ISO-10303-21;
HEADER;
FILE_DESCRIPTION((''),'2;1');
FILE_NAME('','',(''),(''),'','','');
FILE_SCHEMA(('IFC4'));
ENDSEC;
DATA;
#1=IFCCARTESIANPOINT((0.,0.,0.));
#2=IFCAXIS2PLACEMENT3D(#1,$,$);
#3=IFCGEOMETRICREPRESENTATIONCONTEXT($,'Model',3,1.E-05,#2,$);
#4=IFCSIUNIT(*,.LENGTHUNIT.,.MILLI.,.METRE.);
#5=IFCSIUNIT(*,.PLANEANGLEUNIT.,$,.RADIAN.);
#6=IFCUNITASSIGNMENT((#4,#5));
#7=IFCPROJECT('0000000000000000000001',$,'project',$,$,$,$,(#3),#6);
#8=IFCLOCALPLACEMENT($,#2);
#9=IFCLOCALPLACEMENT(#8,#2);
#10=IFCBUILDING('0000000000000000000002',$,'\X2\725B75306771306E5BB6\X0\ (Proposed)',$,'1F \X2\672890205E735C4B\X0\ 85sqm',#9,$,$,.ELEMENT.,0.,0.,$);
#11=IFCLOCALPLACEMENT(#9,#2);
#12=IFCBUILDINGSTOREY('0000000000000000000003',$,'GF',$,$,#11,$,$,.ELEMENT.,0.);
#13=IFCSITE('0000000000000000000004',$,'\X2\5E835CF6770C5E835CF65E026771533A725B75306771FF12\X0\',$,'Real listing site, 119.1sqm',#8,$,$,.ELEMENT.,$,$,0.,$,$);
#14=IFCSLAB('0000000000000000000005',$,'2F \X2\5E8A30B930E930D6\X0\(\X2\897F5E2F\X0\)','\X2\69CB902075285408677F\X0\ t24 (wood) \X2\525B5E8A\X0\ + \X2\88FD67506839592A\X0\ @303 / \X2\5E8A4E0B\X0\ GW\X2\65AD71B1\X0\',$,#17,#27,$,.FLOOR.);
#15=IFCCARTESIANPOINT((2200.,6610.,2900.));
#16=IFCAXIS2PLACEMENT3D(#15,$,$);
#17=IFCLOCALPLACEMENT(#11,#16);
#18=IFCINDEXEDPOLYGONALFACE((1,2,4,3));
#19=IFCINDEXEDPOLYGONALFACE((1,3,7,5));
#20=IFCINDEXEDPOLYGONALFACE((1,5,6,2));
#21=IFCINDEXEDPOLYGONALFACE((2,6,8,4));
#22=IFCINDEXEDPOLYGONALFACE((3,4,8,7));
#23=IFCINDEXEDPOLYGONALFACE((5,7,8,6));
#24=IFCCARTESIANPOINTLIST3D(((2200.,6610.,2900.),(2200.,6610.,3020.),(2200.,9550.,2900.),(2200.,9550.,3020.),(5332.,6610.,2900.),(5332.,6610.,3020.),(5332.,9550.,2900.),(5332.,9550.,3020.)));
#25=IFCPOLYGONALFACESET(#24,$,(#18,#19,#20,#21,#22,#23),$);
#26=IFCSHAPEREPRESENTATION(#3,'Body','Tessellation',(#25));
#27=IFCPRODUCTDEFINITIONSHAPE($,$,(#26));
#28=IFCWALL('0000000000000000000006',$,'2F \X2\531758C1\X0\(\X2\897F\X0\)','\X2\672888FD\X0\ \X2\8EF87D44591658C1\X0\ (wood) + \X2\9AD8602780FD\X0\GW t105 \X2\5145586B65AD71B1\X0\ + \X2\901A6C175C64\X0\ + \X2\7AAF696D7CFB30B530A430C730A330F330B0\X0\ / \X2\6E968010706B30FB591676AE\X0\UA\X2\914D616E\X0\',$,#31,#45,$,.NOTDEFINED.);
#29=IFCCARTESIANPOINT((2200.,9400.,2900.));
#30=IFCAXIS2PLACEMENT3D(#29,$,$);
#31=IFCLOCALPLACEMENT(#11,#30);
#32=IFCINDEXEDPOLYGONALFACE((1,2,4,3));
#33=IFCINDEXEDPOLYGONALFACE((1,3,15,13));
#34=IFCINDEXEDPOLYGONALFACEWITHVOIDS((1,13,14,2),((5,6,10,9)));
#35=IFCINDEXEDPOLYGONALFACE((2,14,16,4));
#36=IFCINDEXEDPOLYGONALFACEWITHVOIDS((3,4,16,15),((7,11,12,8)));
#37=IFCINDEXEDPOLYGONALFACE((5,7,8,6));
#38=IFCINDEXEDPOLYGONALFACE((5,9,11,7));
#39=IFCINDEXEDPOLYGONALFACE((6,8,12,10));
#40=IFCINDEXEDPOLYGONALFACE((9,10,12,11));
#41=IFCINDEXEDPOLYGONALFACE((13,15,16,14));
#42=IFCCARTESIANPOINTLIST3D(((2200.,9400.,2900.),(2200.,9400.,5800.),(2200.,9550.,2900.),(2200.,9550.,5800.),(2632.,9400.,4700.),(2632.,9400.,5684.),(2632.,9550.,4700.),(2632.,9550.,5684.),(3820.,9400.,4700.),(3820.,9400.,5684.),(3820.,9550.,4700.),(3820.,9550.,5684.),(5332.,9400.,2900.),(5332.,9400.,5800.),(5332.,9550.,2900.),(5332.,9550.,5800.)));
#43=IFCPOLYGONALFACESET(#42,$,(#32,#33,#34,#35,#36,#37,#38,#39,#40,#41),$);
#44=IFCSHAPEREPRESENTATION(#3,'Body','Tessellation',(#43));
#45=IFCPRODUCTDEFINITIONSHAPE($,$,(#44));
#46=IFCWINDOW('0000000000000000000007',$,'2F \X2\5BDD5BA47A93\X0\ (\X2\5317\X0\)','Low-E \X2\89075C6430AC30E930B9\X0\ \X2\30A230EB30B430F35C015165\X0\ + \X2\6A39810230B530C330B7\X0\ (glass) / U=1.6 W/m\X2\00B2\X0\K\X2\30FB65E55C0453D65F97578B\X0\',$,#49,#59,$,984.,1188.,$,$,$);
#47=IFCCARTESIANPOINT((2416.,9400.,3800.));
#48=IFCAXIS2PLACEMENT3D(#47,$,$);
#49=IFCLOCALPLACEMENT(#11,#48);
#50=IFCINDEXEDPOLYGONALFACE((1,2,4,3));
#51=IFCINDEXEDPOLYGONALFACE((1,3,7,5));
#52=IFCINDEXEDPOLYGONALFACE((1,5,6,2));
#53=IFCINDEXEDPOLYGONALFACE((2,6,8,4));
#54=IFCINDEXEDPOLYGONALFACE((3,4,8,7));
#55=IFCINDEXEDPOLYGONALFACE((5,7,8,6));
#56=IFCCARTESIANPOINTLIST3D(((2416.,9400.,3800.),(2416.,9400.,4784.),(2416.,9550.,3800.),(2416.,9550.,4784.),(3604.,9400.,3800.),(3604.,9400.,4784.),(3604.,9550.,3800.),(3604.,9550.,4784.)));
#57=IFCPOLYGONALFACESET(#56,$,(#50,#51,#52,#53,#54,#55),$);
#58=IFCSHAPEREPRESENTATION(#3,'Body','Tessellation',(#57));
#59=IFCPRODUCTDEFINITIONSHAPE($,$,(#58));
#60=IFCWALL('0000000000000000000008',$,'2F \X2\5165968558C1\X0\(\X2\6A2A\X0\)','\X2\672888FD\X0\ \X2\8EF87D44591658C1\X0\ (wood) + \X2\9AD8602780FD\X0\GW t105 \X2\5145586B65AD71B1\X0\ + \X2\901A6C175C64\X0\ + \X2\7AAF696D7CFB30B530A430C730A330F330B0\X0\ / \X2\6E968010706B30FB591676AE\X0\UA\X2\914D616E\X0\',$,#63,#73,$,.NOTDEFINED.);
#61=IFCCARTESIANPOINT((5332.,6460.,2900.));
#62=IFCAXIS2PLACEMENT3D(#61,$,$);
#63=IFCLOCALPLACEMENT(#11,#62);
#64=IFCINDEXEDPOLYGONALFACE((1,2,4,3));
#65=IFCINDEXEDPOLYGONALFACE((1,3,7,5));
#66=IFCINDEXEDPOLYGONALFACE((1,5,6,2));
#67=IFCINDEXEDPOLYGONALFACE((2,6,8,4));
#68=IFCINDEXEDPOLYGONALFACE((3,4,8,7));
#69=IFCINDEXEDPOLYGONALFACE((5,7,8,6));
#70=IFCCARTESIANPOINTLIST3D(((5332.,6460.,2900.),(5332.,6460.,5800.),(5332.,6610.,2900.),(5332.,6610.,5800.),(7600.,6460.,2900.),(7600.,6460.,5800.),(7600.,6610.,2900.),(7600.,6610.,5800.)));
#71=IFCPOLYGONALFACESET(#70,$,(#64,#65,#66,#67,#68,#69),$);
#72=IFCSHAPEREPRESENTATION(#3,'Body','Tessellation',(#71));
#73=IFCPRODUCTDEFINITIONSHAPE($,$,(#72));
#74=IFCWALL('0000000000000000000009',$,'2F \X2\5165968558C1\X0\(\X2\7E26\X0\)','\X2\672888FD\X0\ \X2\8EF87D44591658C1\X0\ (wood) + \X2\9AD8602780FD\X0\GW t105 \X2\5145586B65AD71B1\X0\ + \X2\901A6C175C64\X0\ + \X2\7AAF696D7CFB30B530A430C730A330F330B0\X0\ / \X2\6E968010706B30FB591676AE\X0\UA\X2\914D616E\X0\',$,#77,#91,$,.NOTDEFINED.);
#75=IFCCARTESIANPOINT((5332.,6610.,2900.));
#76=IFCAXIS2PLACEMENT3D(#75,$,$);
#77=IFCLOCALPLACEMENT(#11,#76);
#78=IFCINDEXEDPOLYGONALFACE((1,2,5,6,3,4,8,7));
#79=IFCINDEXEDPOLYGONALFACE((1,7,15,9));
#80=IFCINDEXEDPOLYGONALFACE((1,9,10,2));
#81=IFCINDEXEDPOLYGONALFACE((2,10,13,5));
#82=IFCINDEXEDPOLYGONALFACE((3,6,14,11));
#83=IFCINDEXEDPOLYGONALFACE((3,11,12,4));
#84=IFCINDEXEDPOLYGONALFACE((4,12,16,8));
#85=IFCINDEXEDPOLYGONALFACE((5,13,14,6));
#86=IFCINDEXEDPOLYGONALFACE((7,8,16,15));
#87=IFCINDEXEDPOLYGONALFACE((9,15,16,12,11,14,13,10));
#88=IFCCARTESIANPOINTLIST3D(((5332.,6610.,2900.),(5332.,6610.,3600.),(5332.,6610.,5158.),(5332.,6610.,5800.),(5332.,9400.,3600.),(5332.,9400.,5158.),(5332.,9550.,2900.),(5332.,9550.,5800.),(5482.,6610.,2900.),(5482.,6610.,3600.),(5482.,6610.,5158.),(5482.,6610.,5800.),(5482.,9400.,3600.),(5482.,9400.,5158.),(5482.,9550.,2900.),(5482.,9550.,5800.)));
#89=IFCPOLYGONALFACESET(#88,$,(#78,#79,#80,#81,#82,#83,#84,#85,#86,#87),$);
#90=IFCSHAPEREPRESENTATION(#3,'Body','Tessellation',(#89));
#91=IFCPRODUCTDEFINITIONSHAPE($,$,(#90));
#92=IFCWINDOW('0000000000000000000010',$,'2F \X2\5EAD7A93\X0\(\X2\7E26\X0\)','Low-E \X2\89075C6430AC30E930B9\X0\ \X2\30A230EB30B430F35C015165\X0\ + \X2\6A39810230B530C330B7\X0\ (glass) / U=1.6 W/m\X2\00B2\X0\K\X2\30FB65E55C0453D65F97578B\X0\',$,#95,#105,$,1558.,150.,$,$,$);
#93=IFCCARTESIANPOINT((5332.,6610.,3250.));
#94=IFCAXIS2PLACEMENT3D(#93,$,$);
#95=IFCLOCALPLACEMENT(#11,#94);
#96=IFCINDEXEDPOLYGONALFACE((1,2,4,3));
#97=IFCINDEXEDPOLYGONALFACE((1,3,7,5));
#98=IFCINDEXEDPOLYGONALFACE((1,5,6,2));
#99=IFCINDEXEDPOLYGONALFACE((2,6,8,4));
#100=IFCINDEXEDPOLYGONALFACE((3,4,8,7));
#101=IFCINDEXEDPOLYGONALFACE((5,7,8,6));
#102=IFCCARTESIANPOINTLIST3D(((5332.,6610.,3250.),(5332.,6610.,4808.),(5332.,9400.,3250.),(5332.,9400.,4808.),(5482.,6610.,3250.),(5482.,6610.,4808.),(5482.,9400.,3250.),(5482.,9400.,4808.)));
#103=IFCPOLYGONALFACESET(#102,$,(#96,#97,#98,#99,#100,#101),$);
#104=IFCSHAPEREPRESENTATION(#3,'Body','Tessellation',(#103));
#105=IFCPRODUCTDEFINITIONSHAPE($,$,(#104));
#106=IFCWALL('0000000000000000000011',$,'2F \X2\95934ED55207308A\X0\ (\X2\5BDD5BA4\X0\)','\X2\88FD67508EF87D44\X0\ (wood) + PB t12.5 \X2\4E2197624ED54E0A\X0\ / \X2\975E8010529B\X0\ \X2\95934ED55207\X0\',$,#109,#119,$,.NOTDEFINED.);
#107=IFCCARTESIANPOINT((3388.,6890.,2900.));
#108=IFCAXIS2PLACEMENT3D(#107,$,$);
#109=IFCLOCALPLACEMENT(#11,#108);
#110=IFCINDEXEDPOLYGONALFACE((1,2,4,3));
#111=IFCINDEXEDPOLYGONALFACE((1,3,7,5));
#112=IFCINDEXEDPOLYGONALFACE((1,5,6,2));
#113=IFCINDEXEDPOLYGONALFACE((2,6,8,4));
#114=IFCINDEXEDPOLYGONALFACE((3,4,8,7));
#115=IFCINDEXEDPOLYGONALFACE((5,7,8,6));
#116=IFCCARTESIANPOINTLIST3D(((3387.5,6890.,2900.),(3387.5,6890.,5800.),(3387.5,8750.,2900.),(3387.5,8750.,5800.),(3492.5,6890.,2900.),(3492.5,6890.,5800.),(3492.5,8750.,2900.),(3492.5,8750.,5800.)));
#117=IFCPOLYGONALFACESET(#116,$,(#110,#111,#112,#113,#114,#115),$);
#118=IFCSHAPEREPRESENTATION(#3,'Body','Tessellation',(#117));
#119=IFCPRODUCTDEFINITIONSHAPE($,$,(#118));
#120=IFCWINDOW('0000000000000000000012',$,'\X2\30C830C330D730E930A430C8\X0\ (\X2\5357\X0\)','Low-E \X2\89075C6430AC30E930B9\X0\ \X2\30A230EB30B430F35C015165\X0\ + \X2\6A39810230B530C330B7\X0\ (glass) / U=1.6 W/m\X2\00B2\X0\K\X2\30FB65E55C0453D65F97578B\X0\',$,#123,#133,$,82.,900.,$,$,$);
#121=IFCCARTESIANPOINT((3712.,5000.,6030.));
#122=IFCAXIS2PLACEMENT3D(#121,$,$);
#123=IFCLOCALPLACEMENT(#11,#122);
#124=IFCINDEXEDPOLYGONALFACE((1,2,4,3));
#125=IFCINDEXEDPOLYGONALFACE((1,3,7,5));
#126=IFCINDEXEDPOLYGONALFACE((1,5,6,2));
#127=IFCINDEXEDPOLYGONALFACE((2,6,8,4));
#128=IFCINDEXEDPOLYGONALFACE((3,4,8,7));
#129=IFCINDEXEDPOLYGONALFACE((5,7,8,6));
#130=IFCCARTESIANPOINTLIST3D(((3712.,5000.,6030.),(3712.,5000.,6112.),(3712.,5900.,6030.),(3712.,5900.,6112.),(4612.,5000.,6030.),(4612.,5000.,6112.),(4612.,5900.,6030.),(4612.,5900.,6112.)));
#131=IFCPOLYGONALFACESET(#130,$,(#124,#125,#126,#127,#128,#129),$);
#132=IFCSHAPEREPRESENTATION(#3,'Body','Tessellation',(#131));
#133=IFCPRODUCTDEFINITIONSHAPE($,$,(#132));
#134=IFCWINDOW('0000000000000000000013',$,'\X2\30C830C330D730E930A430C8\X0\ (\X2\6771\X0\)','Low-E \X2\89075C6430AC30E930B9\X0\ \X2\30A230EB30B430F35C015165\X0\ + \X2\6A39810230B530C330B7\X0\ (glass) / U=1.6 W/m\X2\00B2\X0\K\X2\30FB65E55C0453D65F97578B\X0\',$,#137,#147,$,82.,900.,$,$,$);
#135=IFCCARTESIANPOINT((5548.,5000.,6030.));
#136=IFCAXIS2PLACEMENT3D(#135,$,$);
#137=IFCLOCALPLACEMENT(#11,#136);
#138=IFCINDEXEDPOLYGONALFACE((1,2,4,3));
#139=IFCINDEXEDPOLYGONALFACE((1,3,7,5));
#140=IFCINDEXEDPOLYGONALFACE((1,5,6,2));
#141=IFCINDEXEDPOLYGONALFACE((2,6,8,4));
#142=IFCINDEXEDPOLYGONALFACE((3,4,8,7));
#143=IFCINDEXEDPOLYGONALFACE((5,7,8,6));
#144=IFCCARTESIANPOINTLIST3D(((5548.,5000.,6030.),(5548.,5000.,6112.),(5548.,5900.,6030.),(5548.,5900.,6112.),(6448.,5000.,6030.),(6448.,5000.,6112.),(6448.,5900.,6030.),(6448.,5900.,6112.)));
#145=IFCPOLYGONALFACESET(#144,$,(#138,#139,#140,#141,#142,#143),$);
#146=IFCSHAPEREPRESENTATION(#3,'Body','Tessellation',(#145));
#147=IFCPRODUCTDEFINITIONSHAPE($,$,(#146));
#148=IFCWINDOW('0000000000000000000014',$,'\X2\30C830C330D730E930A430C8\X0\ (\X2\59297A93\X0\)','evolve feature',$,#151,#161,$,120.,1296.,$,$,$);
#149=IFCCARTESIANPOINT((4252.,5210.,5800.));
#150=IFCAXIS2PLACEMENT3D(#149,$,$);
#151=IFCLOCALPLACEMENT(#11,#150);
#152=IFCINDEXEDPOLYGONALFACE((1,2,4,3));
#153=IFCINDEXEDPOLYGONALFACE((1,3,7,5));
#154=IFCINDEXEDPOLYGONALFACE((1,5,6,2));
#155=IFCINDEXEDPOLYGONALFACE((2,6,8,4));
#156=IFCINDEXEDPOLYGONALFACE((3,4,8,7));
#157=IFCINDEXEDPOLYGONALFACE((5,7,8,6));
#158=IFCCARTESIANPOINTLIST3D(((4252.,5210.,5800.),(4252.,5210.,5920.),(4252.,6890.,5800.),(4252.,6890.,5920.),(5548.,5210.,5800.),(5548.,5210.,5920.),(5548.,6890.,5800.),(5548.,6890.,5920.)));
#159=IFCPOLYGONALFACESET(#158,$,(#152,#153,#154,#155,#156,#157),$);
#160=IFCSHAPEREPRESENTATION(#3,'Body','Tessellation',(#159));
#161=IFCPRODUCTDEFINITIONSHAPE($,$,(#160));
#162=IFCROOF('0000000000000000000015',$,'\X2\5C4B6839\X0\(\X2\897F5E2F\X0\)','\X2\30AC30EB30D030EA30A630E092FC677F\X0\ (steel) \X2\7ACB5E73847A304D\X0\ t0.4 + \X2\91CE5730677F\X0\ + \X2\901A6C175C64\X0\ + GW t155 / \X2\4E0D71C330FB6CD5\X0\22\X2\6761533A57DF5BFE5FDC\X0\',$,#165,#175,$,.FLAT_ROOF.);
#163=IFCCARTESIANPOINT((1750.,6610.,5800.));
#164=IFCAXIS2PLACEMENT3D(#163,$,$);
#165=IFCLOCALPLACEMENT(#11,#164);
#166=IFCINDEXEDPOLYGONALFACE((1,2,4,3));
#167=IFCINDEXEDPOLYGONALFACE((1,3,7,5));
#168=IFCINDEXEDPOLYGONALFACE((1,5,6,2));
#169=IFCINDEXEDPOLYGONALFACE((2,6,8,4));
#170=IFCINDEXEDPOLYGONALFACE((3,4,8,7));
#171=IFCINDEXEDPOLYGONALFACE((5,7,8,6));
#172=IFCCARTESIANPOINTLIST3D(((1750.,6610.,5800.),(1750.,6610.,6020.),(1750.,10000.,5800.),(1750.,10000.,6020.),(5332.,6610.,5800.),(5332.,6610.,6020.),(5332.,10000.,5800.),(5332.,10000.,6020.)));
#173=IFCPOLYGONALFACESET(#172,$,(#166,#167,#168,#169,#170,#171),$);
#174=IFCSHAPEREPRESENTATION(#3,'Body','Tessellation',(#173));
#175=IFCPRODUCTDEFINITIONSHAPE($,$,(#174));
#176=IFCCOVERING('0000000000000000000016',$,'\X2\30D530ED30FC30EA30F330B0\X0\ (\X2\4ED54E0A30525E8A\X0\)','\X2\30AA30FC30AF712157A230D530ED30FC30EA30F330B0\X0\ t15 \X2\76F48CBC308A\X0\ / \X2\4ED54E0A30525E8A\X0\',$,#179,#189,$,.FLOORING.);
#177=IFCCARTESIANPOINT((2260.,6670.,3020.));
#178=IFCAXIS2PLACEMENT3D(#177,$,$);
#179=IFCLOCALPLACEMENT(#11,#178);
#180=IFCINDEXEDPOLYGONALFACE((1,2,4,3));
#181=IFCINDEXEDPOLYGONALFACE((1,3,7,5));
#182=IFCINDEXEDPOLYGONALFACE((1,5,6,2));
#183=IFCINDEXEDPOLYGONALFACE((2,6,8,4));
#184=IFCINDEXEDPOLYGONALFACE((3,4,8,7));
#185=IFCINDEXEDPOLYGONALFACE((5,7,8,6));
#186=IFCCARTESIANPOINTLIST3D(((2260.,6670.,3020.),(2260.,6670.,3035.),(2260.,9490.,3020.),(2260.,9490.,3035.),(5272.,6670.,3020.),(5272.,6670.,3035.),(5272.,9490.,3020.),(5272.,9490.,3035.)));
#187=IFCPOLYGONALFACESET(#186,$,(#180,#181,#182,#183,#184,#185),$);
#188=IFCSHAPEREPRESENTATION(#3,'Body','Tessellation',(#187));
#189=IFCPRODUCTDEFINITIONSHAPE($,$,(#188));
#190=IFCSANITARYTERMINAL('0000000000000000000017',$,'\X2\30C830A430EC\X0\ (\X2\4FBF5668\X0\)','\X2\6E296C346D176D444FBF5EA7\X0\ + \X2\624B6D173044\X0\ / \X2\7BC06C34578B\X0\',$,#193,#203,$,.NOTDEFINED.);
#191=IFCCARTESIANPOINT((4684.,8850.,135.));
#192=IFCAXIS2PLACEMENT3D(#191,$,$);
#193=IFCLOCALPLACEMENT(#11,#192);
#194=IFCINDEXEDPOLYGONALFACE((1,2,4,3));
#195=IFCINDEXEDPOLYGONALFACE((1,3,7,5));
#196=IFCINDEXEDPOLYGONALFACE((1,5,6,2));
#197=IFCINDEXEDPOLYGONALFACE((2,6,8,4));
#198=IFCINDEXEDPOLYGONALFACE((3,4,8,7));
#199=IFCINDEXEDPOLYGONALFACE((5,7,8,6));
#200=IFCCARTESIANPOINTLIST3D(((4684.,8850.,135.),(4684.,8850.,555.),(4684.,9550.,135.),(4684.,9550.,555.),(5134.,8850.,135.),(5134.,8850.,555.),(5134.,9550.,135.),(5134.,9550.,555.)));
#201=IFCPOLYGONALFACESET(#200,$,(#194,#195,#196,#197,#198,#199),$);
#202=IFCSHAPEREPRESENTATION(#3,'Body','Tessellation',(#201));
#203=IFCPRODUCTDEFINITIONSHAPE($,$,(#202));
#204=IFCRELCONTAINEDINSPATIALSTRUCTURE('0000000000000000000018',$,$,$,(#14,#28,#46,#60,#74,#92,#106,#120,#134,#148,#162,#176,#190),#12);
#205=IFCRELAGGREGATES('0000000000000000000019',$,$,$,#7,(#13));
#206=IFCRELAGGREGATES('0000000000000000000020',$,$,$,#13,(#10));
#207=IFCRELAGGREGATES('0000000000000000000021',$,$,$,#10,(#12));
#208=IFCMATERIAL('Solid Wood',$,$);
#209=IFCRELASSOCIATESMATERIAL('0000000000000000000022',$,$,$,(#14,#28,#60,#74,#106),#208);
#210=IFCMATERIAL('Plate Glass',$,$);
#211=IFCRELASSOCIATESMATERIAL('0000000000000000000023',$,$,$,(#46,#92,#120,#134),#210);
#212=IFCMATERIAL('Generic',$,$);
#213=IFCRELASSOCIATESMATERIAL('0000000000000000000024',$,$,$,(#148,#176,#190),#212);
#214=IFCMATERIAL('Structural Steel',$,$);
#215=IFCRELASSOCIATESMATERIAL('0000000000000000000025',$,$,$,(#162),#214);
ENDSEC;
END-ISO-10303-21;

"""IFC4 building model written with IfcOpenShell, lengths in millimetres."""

from ifc_helpers import new_model, si_unit, frame, frame_2d, origin, place, context, project, spatial, rectangle, extrude, material, element, fill, save


model = new_model("IFC4")

# Units and contexts
model_context = context("Model", 3, precision=1e-05, world=origin())
ifc_project = project(units=[si_unit("LENGTHUNIT", "METRE", prefix="MILLI"), si_unit("PLANEANGLEUNIT", "RADIAN")], contexts=[model_context])

# Site, building, storey
site_placement = place(None, origin())
site = spatial("IfcSite", under=ifc_project, at=site_placement, Name="広島県広島市東区牛田東２", ObjectType="Real listing site, 119.1sqm", CompositionType="ELEMENT", RefElevation=0.0)
building_placement = place(site_placement, origin())
building = spatial("IfcBuilding", under=site, at=building_placement, Name="牛田東の家 (Proposed)", ObjectType="1F 木造平屋 85sqm", CompositionType="ELEMENT", ElevationOfRefHeight=0.0, ElevationOfTerrain=0.0)
storey_placement = place(building_placement, origin())
storey = spatial("IfcBuildingStorey", under=building, at=storey_placement, Name="GF", CompositionType="ELEMENT", Elevation=0.0)

# Slab
ifc_material_1 = material(Name="Solid Wood")
slab_placement = place(storey_placement, frame((2200.0, 6610.0, 2900.0)))
element("IfcSlab", 1, at=slab_placement, inside=storey, material=ifc_material_1, Name="2F 床スラブ(西帯)", Description="構造用合板 t24 (wood) 剛床 + 製材根太 @303 / 床下 GW断熱", PredefinedType="FLOOR", context=model_context, shape_type="SweptSolid", body=[
    extrude(rectangle(XDim=3132.0, YDim=2940.0, at=frame_2d((1566.0, 1470.0))), frame((2200.0, 6610.0, 2900.0)), (0.0, 0.0, 1.0), 120.0),
])

# Wall, opening, window
wall_1_placement = place(storey_placement, frame((2200.0, 9400.0, 2900.0)))
wall_1 = element("IfcWall", 2, at=wall_1_placement, inside=storey, material=ifc_material_1, Name="2F 北壁(西)", Description="木製 軸組外壁 (wood) + 高性能GW t105 充填断熱 + 通気層 + 窯業系サイディング / 準耐火・外皮UA配慮", PredefinedType="NOTDEFINED", context=model_context, shape_type="SweptSolid", body=[
    extrude(rectangle(XDim=3132.0, YDim=150.0, at=frame_2d((1566.0, 75.0))), frame((2200.0, 9400.0, 2900.0)), (0.0, 0.0, 1.0), 2900.0),
])
opening_1_placement = place(storey_placement, frame((2416.0, 9400.0, 3800.0)))
opening_1 = element("IfcOpeningElement", 3, at=opening_1_placement, cuts=wall_1, PredefinedType="NOTDEFINED", context=model_context, shape_type="SweptSolid", body=[
    extrude(rectangle(XDim=1188.0, YDim=150.0, at=frame_2d((594.0, 75.0))), frame((2416.0, 9400.0, 3800.0)), (0.0, 0.0, 1.0), 984.0),
])
ifc_material_2 = material(Name="Plate Glass")
window_1_placement = place(storey_placement, frame((2416.0, 9400.0, 3800.0)))
window_1 = element("IfcWindow", 4, at=window_1_placement, inside=storey, material=ifc_material_2, Name="2F 寝室窓 (北)", Description="Low-E 複層ガラス アルゴン封入 + 樹脂サッシ (glass) / U=1.6 W/m²K・日射取得型", OverallHeight=984.0, OverallWidth=1188.0, context=model_context, shape_type="SweptSolid", body=[
    extrude(rectangle(XDim=1188.0, YDim=150.0, at=frame_2d((594.0, 75.0))), frame((2416.0, 9400.0, 3800.0)), (0.0, 0.0, 1.0), 984.0),
])
fill(opening_1, window_1)

# Wall
wall_2_placement = place(storey_placement, frame((5332.0, 6460.0, 2900.0)))
element("IfcWall", 5, at=wall_2_placement, inside=storey, material=ifc_material_1, Name="2F 入隅壁(横)", Description="木製 軸組外壁 (wood) + 高性能GW t105 充填断熱 + 通気層 + 窯業系サイディング / 準耐火・外皮UA配慮", PredefinedType="NOTDEFINED", context=model_context, shape_type="SweptSolid", body=[
    extrude(rectangle(XDim=2268.0, YDim=150.0, at=frame_2d((1134.0, 75.0))), frame((5332.0, 6460.0, 2900.0)), (0.0, 0.0, 1.0), 2900.0),
])

# Wall, opening, window
wall_3_placement = place(storey_placement, frame((5332.0, 6610.0, 2900.0)))
wall_3 = element("IfcWall", 6, at=wall_3_placement, inside=storey, material=ifc_material_1, Name="2F 入隅壁(縦)", Description="木製 軸組外壁 (wood) + 高性能GW t105 充填断熱 + 通気層 + 窯業系サイディング / 準耐火・外皮UA配慮", PredefinedType="NOTDEFINED", context=model_context, shape_type="SweptSolid", body=[
    extrude(rectangle(XDim=150.0, YDim=2940.0, at=frame_2d((75.0, 1470.0))), frame((5332.0, 6610.0, 2900.0)), (0.0, 0.0, 1.0), 2900.0),
])
opening_2_placement = place(storey_placement, frame((5332.0, 6610.0, 3250.0)))
opening_2 = element("IfcOpeningElement", 7, at=opening_2_placement, cuts=wall_3, PredefinedType="NOTDEFINED", context=model_context, shape_type="SweptSolid", body=[
    extrude(rectangle(XDim=150.0, YDim=2790.0, at=frame_2d((75.0, 1395.0))), frame((5332.0, 6610.0, 3250.0)), (0.0, 0.0, 1.0), 1558.0),
])
window_2_placement = place(storey_placement, frame((5332.0, 6610.0, 3250.0)))
window_2 = element("IfcWindow", 8, at=window_2_placement, inside=storey, material=ifc_material_2, Name="2F 庭窓(縦)", Description="Low-E 複層ガラス アルゴン封入 + 樹脂サッシ (glass) / U=1.6 W/m²K・日射取得型", OverallHeight=1558.0, OverallWidth=150.0, context=model_context, shape_type="SweptSolid", body=[
    extrude(rectangle(XDim=150.0, YDim=2790.0, at=frame_2d((75.0, 1395.0))), frame((5332.0, 6610.0, 3250.0)), (0.0, 0.0, 1.0), 1558.0),
])
fill(opening_2, window_2)

# Wall
wall_4_placement = place(storey_placement, frame((3388.0, 6890.0, 2900.0)))
element("IfcWall", 9, at=wall_4_placement, inside=storey, material=ifc_material_1, Name="2F 間仕切り (寝室)", Description="製材軸組 (wood) + PB t12.5 両面仕上 / 非耐力 間仕切", PredefinedType="NOTDEFINED", context=model_context, shape_type="SweptSolid", body=[
    extrude(rectangle(XDim=105.0, YDim=1860.0, at=frame_2d((52.0, 930.0))), frame((3388.0, 6890.0, 2900.0)), (0.0, 0.0, 1.0), 2900.0),
])

# Windows
window_3_placement = place(storey_placement, frame((3712.0, 5000.0, 6030.0)))
element("IfcWindow", 10, at=window_3_placement, inside=storey, material=ifc_material_2, Name="トップライト (南)", Description="Low-E 複層ガラス アルゴン封入 + 樹脂サッシ (glass) / U=1.6 W/m²K・日射取得型", OverallHeight=82.0, OverallWidth=900.0, context=model_context, shape_type="SweptSolid", body=[
    extrude(rectangle(XDim=900.0, YDim=900.0, at=frame_2d((450.0, 450.0))), frame((3712.0, 5000.0, 6030.0)), (0.0, 0.0, 1.0), 82.0),
])
window_4_placement = place(storey_placement, frame((5548.0, 5000.0, 6030.0)))
element("IfcWindow", 11, at=window_4_placement, inside=storey, material=ifc_material_2, Name="トップライト (東)", Description="Low-E 複層ガラス アルゴン封入 + 樹脂サッシ (glass) / U=1.6 W/m²K・日射取得型", OverallHeight=82.0, OverallWidth=900.0, context=model_context, shape_type="SweptSolid", body=[
    extrude(rectangle(XDim=900.0, YDim=900.0, at=frame_2d((450.0, 450.0))), frame((5548.0, 5000.0, 6030.0)), (0.0, 0.0, 1.0), 82.0),
])
ifc_material_3 = material(Name="Generic")
window_5_placement = place(storey_placement, frame((4252.0, 5210.0, 5800.0)))
element("IfcWindow", 12, at=window_5_placement, inside=storey, material=ifc_material_3, Name="トップライト (天窓)", Description="evolve feature", OverallHeight=120.0, OverallWidth=1296.0, context=model_context, shape_type="SweptSolid", body=[
    extrude(rectangle(XDim=1296.0, YDim=1680.0, at=frame_2d((648.0, 840.0))), frame((4252.0, 5210.0, 5800.0)), (0.0, 0.0, 1.0), 120.0),
])

# Roof
ifc_material_4 = material(Name="Structural Steel")
for number, where, name in (
    (13, (1750.0, 6610.0, 5800.0), "屋根(西帯)"),
):
    element("IfcRoof", number, at=place(storey_placement, frame(where)), inside=storey, material=ifc_material_4, Name=name, Description="ガルバリウム鋼板 (steel) 立平葺き t0.4 + 野地板 + 通気層 + GW t155 / 不燃・法22条区域対応", PredefinedType="FLAT_ROOF", context=model_context, shape_type="SweptSolid", body=[
        extrude(rectangle(XDim=3582.0, YDim=3390.0, at=frame_2d((1791.0, 1695.0))), frame((1750.0, 6610.0, 5800.0)), (0.0, 0.0, 1.0), 220.0),
    ])

# Covering
covering_placement = place(storey_placement, frame((2260.0, 6670.0, 3020.0)))
element("IfcCovering", 14, at=covering_placement, inside=storey, material=ifc_material_3, Name="フローリング (仕上げ床)", Description="オーク無垢フローリング t15 直貼り / 仕上げ床", PredefinedType="FLOORING", context=model_context, shape_type="SweptSolid", body=[
    extrude(rectangle(XDim=3012.0, YDim=2820.0, at=frame_2d((1506.0, 1410.0))), frame((2260.0, 6670.0, 3020.0)), (0.0, 0.0, 1.0), 15.0),
])

# Sanitary terminal
sanitary_terminal_placement = place(storey_placement, frame((4684.0, 8850.0, 135.0)))
element("IfcSanitaryTerminal", 15, at=sanitary_terminal_placement, inside=storey, material=ifc_material_3, Name="トイレ (便器)", Description="温水洗浄便座 + 手洗い / 節水型", PredefinedType="NOTDEFINED", context=model_context, shape_type="SweptSolid", body=[
    extrude(rectangle(XDim=450.0, YDim=700.0, at=frame_2d((225.0, 350.0))), frame((4684.0, 8850.0, 135.0)), (0.0, 0.0, 1.0), 420.0),
])

save(model, "model.ifc")
